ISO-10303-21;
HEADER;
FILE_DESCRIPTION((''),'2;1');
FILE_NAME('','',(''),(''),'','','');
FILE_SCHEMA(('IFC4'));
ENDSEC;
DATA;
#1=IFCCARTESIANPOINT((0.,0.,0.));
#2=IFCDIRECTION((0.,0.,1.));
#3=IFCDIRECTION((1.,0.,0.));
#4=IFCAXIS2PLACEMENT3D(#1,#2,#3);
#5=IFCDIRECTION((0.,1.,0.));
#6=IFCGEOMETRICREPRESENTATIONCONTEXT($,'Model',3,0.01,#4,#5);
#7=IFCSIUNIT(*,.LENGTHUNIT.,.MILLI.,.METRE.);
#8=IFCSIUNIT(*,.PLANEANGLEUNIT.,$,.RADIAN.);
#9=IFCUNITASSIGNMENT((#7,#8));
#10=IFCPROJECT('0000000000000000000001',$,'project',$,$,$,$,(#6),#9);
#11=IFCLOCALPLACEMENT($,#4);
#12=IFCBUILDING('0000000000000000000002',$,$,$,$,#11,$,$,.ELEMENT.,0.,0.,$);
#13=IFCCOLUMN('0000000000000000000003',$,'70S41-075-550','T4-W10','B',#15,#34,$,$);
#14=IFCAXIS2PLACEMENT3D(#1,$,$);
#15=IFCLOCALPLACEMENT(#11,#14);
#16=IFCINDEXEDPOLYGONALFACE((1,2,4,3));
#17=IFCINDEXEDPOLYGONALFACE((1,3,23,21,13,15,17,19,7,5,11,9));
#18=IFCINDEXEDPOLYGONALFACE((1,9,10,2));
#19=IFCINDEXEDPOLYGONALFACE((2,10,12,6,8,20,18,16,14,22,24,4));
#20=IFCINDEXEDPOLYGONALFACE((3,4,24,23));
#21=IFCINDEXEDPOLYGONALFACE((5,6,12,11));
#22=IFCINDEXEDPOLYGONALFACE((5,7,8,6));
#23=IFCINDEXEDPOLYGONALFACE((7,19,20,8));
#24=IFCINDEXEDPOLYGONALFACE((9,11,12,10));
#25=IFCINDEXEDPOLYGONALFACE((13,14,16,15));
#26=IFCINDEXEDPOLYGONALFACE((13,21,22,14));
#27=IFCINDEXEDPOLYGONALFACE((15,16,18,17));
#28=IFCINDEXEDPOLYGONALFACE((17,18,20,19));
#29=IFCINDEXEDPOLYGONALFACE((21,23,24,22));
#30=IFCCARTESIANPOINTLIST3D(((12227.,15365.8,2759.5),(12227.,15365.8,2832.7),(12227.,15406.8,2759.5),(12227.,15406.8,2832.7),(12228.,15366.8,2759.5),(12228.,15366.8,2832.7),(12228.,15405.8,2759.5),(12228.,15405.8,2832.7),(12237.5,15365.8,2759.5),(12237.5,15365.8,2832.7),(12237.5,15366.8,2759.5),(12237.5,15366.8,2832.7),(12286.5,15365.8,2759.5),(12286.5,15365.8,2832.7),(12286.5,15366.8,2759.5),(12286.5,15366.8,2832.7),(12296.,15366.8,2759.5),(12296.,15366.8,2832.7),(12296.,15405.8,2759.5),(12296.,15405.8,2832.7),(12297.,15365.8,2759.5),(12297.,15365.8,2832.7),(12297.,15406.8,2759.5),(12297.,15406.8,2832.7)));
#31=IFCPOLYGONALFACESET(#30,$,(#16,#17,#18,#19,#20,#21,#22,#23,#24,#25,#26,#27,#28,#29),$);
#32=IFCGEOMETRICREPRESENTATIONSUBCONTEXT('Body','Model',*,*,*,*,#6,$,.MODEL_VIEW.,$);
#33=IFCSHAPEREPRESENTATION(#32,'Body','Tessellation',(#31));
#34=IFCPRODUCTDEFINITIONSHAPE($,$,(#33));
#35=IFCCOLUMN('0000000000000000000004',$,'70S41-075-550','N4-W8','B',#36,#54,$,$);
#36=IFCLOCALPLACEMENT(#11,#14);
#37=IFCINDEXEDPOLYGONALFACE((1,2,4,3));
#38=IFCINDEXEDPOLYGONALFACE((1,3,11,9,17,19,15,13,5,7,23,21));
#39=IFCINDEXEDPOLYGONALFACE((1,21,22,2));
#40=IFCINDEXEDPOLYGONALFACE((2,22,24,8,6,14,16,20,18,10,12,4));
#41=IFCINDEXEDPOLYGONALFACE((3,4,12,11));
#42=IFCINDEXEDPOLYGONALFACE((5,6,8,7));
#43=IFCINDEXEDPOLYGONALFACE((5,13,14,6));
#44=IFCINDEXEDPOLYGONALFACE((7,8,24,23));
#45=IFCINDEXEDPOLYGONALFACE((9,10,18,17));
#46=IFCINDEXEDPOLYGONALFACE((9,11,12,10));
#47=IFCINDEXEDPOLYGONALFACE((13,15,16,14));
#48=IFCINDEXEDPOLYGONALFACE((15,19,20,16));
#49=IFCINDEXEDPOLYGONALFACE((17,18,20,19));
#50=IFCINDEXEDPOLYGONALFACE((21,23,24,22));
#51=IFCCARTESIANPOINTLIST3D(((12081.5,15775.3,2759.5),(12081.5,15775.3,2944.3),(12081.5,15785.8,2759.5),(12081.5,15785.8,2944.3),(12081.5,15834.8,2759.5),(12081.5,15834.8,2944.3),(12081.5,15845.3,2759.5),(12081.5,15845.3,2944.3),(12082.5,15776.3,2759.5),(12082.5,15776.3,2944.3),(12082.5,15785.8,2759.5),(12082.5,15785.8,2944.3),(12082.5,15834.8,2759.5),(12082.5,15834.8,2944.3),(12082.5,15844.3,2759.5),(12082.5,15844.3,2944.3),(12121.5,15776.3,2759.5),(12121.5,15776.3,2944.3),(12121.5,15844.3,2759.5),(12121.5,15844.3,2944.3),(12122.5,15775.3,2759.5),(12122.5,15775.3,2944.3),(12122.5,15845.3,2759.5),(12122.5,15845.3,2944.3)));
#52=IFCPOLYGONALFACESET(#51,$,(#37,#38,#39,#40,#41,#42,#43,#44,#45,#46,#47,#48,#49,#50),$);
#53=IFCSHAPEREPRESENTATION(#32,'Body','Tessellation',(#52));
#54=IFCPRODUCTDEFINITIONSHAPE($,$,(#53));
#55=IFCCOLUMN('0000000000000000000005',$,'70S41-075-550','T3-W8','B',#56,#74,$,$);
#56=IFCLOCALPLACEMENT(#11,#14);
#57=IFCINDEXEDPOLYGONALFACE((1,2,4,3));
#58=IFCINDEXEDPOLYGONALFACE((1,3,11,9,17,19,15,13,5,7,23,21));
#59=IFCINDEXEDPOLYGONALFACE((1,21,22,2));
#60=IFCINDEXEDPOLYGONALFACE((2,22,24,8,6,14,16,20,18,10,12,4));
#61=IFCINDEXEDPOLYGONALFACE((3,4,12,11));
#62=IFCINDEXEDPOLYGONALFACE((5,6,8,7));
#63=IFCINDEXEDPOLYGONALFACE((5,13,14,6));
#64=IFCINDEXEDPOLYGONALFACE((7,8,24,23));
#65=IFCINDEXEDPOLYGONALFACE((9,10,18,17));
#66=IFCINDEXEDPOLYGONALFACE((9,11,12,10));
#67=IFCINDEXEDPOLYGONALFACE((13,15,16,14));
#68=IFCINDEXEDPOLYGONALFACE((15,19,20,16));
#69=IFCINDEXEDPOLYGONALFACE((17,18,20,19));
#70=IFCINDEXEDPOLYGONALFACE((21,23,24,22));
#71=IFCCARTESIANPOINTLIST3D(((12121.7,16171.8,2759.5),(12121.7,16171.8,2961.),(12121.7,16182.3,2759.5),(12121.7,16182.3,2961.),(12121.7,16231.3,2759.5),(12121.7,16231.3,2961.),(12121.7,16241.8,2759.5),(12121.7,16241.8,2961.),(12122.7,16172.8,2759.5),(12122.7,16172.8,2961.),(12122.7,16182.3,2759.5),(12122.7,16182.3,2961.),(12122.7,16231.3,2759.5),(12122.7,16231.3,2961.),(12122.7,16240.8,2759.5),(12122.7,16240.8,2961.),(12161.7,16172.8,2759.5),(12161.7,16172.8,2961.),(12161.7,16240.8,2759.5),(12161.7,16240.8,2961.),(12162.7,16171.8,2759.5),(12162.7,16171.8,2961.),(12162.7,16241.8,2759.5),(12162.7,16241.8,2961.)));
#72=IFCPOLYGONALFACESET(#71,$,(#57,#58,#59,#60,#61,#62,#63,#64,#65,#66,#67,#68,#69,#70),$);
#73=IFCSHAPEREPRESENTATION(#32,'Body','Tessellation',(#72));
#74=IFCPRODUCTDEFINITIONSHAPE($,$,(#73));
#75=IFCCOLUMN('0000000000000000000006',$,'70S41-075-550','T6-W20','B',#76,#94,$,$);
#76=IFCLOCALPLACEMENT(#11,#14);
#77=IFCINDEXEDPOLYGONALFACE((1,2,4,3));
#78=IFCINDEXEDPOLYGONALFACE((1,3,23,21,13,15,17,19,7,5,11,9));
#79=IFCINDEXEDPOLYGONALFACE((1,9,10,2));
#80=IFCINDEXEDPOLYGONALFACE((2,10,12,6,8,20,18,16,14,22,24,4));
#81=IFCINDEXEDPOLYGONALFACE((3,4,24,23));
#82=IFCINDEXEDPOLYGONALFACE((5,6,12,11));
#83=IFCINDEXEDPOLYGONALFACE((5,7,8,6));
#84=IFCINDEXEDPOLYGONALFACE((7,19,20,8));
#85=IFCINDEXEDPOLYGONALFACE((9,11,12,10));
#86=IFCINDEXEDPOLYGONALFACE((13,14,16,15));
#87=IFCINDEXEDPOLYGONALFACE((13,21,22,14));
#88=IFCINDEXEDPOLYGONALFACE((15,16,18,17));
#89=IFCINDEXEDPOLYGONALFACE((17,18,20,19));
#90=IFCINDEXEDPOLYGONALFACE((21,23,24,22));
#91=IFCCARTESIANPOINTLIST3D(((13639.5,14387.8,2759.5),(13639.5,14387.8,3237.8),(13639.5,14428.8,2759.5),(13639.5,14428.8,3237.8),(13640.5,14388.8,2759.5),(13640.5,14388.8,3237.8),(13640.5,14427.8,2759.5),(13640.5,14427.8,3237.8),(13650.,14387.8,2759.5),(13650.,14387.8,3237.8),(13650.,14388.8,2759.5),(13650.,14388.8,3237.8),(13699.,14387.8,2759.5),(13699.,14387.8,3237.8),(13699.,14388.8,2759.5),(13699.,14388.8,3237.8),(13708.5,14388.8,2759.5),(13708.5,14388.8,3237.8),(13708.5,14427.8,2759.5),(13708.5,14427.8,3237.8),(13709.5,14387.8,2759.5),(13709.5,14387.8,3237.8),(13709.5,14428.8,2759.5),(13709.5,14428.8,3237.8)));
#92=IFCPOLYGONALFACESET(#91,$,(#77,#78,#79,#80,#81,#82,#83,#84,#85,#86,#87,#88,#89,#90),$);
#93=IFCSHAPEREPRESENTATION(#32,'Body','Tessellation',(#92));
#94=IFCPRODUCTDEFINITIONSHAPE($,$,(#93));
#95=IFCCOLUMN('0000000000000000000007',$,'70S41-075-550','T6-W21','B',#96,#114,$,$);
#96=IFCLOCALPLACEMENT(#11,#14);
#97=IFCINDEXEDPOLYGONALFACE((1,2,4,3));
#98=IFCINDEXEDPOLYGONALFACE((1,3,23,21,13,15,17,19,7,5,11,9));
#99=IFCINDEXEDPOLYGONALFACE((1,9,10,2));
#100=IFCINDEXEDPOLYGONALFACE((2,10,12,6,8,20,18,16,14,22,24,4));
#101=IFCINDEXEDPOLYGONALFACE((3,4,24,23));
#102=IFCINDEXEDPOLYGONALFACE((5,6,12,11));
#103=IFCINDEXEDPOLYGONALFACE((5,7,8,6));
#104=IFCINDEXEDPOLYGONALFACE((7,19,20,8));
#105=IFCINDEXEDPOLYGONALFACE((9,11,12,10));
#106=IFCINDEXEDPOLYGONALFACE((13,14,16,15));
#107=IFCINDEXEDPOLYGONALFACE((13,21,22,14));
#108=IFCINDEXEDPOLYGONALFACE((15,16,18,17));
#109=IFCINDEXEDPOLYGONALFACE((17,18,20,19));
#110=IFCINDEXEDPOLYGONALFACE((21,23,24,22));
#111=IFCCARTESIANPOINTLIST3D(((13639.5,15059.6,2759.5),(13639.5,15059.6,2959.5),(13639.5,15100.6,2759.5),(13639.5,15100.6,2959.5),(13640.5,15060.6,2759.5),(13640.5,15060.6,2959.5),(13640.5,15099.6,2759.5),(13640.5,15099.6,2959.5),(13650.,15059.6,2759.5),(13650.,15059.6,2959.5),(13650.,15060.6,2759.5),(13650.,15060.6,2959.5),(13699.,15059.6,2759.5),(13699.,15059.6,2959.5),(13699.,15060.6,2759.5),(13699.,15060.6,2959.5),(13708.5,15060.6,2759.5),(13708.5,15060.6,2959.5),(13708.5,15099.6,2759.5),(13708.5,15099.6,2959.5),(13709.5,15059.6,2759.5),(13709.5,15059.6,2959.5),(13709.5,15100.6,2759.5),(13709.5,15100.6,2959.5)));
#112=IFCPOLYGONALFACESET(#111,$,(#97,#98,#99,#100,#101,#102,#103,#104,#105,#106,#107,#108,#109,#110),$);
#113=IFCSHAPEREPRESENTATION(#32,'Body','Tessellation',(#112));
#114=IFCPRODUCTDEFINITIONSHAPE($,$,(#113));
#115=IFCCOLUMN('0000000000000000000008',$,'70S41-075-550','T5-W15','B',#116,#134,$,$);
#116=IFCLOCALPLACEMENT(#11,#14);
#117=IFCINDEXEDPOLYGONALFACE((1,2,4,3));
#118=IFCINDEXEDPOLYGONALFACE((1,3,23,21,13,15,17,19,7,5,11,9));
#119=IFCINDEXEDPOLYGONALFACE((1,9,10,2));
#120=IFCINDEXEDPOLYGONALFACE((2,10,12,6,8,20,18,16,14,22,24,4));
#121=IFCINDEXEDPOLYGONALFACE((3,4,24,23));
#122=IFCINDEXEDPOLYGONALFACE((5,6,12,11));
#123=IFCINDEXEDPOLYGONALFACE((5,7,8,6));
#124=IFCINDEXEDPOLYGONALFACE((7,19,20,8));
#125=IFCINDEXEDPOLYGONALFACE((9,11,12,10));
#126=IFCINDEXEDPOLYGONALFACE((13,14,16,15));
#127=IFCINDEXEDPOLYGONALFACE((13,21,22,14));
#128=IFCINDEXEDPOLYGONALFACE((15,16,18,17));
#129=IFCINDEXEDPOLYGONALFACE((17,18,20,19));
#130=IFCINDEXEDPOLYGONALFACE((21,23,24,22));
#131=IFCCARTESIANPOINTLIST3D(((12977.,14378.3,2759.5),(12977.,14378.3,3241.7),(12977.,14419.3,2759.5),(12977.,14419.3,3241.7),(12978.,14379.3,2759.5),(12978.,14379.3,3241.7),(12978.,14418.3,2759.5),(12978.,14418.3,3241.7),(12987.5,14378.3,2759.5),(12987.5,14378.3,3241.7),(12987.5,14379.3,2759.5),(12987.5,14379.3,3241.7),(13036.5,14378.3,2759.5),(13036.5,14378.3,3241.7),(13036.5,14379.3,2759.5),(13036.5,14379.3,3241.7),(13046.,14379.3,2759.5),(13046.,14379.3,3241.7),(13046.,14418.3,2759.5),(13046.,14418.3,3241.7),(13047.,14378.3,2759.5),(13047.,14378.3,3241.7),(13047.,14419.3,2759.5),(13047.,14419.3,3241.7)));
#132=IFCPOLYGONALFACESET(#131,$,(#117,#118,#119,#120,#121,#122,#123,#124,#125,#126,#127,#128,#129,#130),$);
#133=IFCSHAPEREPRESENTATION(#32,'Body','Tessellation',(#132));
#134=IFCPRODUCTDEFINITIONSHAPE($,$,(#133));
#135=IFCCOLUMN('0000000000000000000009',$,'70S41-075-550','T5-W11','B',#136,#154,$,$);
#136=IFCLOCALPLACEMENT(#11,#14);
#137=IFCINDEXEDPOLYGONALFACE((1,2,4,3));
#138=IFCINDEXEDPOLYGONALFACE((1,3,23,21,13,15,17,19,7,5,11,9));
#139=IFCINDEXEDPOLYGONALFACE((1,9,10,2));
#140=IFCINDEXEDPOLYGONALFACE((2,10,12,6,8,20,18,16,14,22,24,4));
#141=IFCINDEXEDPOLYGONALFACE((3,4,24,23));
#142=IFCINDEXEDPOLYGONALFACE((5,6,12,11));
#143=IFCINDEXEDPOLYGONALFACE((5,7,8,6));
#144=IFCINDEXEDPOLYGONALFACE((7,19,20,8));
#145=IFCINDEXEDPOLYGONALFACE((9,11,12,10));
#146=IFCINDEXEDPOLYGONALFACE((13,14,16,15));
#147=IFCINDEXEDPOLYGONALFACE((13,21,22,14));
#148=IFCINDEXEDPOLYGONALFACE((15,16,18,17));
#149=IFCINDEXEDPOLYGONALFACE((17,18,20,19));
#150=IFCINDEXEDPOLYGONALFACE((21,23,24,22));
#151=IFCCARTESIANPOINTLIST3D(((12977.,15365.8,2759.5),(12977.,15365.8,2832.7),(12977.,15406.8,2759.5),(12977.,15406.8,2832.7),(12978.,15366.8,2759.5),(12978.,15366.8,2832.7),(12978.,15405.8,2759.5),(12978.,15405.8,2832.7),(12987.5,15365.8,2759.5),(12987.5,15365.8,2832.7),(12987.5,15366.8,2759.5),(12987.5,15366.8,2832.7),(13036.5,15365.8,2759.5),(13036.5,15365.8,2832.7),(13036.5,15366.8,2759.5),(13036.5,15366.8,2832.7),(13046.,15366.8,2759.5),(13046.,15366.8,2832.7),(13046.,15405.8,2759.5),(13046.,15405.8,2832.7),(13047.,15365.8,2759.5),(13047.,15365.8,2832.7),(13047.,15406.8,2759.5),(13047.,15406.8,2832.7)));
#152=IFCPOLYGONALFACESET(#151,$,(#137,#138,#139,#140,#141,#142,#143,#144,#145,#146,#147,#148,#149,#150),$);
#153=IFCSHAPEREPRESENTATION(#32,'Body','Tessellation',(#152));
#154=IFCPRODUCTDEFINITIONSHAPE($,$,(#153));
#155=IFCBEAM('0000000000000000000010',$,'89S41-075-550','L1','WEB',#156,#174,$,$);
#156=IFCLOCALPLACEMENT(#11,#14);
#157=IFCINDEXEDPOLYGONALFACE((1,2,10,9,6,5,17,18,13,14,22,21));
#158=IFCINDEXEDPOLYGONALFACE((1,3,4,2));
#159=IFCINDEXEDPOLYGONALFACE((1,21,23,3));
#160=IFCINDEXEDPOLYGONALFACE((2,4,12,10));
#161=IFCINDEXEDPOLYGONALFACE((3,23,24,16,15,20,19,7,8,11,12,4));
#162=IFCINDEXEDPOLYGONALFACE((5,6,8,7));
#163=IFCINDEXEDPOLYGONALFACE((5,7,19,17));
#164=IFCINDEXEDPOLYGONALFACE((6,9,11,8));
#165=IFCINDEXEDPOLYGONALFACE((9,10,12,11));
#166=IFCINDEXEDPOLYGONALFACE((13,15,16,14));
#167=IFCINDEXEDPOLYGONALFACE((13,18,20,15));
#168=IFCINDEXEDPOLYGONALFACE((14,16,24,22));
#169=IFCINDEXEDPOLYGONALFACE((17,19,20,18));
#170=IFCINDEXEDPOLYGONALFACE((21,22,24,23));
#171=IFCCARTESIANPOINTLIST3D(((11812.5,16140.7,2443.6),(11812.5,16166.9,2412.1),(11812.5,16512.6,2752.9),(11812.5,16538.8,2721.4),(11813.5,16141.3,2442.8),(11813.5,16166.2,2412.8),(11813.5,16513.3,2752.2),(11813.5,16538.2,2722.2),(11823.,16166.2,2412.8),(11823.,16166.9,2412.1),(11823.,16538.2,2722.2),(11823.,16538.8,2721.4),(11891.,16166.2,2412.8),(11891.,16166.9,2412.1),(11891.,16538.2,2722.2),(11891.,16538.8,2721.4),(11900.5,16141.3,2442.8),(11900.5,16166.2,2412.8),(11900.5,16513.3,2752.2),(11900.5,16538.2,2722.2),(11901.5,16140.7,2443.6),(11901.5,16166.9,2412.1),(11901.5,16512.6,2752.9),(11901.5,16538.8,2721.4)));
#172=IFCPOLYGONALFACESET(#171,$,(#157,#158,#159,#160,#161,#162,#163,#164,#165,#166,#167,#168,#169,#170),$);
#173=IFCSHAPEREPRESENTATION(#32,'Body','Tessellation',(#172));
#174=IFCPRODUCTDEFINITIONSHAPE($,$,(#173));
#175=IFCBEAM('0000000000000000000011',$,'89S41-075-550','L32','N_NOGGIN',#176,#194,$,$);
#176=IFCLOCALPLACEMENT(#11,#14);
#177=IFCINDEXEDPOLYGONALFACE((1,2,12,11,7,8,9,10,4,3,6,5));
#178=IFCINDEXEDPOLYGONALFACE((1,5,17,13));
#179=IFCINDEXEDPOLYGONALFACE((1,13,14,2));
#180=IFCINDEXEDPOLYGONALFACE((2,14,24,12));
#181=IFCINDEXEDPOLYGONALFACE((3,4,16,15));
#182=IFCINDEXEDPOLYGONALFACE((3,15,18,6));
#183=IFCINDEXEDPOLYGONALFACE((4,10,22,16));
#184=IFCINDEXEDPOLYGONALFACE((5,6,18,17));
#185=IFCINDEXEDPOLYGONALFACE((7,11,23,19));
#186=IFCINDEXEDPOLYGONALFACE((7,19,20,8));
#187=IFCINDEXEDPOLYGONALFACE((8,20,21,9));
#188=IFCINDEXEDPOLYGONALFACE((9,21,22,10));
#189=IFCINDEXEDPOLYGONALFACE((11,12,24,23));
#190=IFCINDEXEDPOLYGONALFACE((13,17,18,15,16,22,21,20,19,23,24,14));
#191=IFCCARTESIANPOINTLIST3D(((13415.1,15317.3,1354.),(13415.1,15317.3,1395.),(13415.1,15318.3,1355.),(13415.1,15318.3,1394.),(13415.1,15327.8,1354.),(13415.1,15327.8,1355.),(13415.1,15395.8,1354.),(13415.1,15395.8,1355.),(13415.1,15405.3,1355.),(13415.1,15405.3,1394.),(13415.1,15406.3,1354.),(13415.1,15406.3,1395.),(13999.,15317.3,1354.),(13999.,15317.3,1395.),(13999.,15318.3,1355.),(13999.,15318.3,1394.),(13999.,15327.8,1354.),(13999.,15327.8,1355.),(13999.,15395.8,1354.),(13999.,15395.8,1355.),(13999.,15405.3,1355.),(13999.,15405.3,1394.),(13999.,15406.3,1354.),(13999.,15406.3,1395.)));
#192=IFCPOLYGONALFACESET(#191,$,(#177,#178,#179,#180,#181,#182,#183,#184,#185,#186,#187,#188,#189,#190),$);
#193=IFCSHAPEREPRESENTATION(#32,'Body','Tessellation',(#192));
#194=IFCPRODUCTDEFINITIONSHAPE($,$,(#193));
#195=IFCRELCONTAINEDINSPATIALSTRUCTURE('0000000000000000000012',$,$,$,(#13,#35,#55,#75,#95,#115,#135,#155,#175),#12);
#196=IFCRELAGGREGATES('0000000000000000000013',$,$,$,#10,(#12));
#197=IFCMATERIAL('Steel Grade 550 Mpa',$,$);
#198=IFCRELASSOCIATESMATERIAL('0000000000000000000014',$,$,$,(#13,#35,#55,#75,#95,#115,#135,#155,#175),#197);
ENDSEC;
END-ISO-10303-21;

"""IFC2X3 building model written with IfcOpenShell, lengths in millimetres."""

from ifc_helpers import new_model, si_unit, direction, frame, origin, origin_with_axes, origin_2d_with_axis, place, context, subcontext, project, spatial, c_section, extrude, source, transform, mapped, material, element, save


model = new_model("IFC2X3")

# Units and contexts
model_context = context("Model", 3, precision=0.01, world=origin_with_axes(), true_north=direction((0.0, 1.0, 0.0)))
body_context = subcontext(model_context, "Body", "Model", "MODEL_VIEW")
ifc_project = project(units=[si_unit("LENGTHUNIT", "METRE", prefix="MILLI"), si_unit("PLANEANGLEUNIT", "RADIAN")], contexts=[model_context])

# Building
building_placement = place(None, origin_with_axes())
building = spatial("IfcBuilding", under=ifc_project, at=building_placement, CompositionType="ELEMENT", ElevationOfRefHeight=0.0, ElevationOfTerrain=0.0)

# Columns
ifc_material = material(Name="Steel Grade 550 Mpa")
shared_shape_1 = source(origin(), body_context, "Body", "SweptSolid", [
    extrude(c_section(Depth=70.0, Width=41.0, WallThickness=1.0, Girth=10.5, at=origin_2d_with_axis()), origin_with_axes(), (0.0, 0.0, 1.0), 73.2),
])
column_1_placement = place(None, frame((12262.0, 15386.3, 2759.5), z_axis=(0.0, 0.0, 1.0), x_axis=(0.0, -1.0, 0.0)))
element("IfcColumn", 1, at=column_1_placement, inside=building, material=ifc_material, Name="70S41-075-550", Description="T4-W10", ObjectType="B", context=body_context, shape_type="MappedRepresentation", body=[
    mapped(shared_shape_1, transform((0.0, 0.0, 0.0), scale=1.0)),
])
shared_shape_2 = source(origin(), body_context, "Body", "SweptSolid", [
    extrude(c_section(Depth=70.0, Width=41.0, WallThickness=1.0, Girth=10.5, at=origin_2d_with_axis()), origin_with_axes(), (0.0, 0.0, 1.0), 184.8),
])
column_2_placement = place(None, frame((12102.0, 15810.3, 2759.5), z_axis=(0.0, 0.0, 1.0), x_axis=(-1.0, 0.0, 0.0)))
element("IfcColumn", 2, at=column_2_placement, inside=building, material=ifc_material, Name="70S41-075-550", Description="N4-W8", ObjectType="B", context=body_context, shape_type="MappedRepresentation", body=[
    mapped(shared_shape_2, transform((0.0, 0.0, 0.0), scale=1.0)),
])
shared_shape_3 = source(origin(), body_context, "Body", "SweptSolid", [
    extrude(c_section(Depth=70.0, Width=41.0, WallThickness=1.0, Girth=10.5, at=origin_2d_with_axis()), origin_with_axes(), (0.0, 0.0, 1.0), 201.5),
])
column_3_placement = place(None, frame((12142.2, 16206.8, 2759.5), z_axis=(0.0, 0.0, 1.0), x_axis=(-1.0, 0.0, 0.0)))
element("IfcColumn", 3, at=column_3_placement, inside=building, material=ifc_material, Name="70S41-075-550", Description="T3-W8", ObjectType="B", context=body_context, shape_type="MappedRepresentation", body=[
    mapped(shared_shape_3, transform((0.0, 0.0, 0.0), scale=1.0)),
])
shared_shape_4 = source(origin(), body_context, "Body", "SweptSolid", [
    extrude(c_section(Depth=70.0, Width=41.0, WallThickness=1.0, Girth=10.5, at=origin_2d_with_axis()), origin_with_axes(), (0.0, 0.0, 1.0), 478.3),
])
column_4_placement = place(None, frame((13674.5, 14408.3, 2759.5), z_axis=(0.0, 0.0, 1.0), x_axis=(0.000004, -1.0, 0.0)))
element("IfcColumn", 4, at=column_4_placement, inside=building, material=ifc_material, Name="70S41-075-550", Description="T6-W20", ObjectType="B", context=body_context, shape_type="MappedRepresentation", body=[
    mapped(shared_shape_4, transform((0.0, 0.0, 0.0), scale=1.0)),
])
shared_shape_5 = source(origin(), body_context, "Body", "SweptSolid", [
    extrude(c_section(Depth=70.0, Width=41.0, WallThickness=1.0, Girth=10.5, at=origin_2d_with_axis()), origin_with_axes(), (0.0, 0.0, 1.0), 200.0),
])
column_5_placement = place(None, frame((13674.5, 15080.1, 2759.5), z_axis=(0.0, 0.0, 1.0), x_axis=(0.000004, -1.0, 0.0)))
element("IfcColumn", 5, at=column_5_placement, inside=building, material=ifc_material, Name="70S41-075-550", Description="T6-W21", ObjectType="B", context=body_context, shape_type="MappedRepresentation", body=[
    mapped(shared_shape_5, transform((0.0, 0.0, 0.0), scale=1.0)),
])
shared_shape_6 = source(origin(), body_context, "Body", "SweptSolid", [
    extrude(c_section(Depth=70.0, Width=41.0, WallThickness=1.0, Girth=10.5, at=origin_2d_with_axis()), origin_with_axes(), (0.0, 0.0, 1.0), 482.2),
])
column_6_placement = place(None, frame((13012.0, 14398.8, 2759.5), z_axis=(0.0, 0.0, 1.0), x_axis=(0.000004, -1.0, 0.0)))
element("IfcColumn", 6, at=column_6_placement, inside=building, material=ifc_material, Name="70S41-075-550", Description="T5-W15", ObjectType="B", context=body_context, shape_type="MappedRepresentation", body=[
    mapped(shared_shape_6, transform((0.0, 0.0, 0.0), scale=1.0)),
])
shared_shape_7 = source(origin(), body_context, "Body", "SweptSolid", [
    extrude(c_section(Depth=70.0, Width=41.0, WallThickness=1.0, Girth=10.5, at=origin_2d_with_axis()), origin_with_axes(), (0.0, 0.0, 1.0), 73.2),
])
column_7_placement = place(None, frame((13012.0, 15386.3, 2759.5), z_axis=(0.0, 0.0, 1.0), x_axis=(0.000004, -1.0, 0.0)))
element("IfcColumn", 7, at=column_7_placement, inside=building, material=ifc_material, Name="70S41-075-550", Description="T5-W11", ObjectType="B", context=body_context, shape_type="MappedRepresentation", body=[
    mapped(shared_shape_7, transform((0.0, 0.0, 0.0), scale=1.0)),
])

# Beams
shared_shape_8 = source(origin(), body_context, "Body", "SweptSolid", [
    extrude(c_section(Depth=89.0, Width=41.0, WallThickness=1.0, Girth=10.5, at=origin_2d_with_axis()), origin_with_axes(), (0.0, 0.0, 1.0), 483.8),
])
beam_1_placement = place(None, frame((11857.0, 16153.8, 2427.8), z_axis=(0.0, 0.76885, 0.639429), x_axis=(0.0, 0.639429, -0.76885)))
element("IfcBeam", 8, at=beam_1_placement, inside=building, material=ifc_material, Name="89S41-075-550", Description="L1", ObjectType="WEB", context=body_context, shape_type="MappedRepresentation", body=[
    mapped(shared_shape_8, transform((0.0, 0.0, 0.0), scale=1.0)),
])
shared_shape_9 = source(origin(), body_context, "Body", "SweptSolid", [
    extrude(c_section(Depth=89.0, Width=41.0, WallThickness=1.0, Girth=10.5, at=origin_2d_with_axis()), origin_with_axes(), (0.0, 0.0, 1.0), 584.0),
])
beam_2_placement = place(None, frame((13415.1, 15361.8, 1374.5), z_axis=(1.0, 0.0, 0.0), x_axis=(0.0, 0.0, -1.0)))
element("IfcBeam", 9, at=beam_2_placement, inside=building, material=ifc_material, Name="89S41-075-550", Description="L32", ObjectType="N_NOGGIN", context=body_context, shape_type="MappedRepresentation", body=[
    mapped(shared_shape_9, transform((0.0, 0.0, 0.0), scale=1.0)),
])

save(model, "model.ifc")
